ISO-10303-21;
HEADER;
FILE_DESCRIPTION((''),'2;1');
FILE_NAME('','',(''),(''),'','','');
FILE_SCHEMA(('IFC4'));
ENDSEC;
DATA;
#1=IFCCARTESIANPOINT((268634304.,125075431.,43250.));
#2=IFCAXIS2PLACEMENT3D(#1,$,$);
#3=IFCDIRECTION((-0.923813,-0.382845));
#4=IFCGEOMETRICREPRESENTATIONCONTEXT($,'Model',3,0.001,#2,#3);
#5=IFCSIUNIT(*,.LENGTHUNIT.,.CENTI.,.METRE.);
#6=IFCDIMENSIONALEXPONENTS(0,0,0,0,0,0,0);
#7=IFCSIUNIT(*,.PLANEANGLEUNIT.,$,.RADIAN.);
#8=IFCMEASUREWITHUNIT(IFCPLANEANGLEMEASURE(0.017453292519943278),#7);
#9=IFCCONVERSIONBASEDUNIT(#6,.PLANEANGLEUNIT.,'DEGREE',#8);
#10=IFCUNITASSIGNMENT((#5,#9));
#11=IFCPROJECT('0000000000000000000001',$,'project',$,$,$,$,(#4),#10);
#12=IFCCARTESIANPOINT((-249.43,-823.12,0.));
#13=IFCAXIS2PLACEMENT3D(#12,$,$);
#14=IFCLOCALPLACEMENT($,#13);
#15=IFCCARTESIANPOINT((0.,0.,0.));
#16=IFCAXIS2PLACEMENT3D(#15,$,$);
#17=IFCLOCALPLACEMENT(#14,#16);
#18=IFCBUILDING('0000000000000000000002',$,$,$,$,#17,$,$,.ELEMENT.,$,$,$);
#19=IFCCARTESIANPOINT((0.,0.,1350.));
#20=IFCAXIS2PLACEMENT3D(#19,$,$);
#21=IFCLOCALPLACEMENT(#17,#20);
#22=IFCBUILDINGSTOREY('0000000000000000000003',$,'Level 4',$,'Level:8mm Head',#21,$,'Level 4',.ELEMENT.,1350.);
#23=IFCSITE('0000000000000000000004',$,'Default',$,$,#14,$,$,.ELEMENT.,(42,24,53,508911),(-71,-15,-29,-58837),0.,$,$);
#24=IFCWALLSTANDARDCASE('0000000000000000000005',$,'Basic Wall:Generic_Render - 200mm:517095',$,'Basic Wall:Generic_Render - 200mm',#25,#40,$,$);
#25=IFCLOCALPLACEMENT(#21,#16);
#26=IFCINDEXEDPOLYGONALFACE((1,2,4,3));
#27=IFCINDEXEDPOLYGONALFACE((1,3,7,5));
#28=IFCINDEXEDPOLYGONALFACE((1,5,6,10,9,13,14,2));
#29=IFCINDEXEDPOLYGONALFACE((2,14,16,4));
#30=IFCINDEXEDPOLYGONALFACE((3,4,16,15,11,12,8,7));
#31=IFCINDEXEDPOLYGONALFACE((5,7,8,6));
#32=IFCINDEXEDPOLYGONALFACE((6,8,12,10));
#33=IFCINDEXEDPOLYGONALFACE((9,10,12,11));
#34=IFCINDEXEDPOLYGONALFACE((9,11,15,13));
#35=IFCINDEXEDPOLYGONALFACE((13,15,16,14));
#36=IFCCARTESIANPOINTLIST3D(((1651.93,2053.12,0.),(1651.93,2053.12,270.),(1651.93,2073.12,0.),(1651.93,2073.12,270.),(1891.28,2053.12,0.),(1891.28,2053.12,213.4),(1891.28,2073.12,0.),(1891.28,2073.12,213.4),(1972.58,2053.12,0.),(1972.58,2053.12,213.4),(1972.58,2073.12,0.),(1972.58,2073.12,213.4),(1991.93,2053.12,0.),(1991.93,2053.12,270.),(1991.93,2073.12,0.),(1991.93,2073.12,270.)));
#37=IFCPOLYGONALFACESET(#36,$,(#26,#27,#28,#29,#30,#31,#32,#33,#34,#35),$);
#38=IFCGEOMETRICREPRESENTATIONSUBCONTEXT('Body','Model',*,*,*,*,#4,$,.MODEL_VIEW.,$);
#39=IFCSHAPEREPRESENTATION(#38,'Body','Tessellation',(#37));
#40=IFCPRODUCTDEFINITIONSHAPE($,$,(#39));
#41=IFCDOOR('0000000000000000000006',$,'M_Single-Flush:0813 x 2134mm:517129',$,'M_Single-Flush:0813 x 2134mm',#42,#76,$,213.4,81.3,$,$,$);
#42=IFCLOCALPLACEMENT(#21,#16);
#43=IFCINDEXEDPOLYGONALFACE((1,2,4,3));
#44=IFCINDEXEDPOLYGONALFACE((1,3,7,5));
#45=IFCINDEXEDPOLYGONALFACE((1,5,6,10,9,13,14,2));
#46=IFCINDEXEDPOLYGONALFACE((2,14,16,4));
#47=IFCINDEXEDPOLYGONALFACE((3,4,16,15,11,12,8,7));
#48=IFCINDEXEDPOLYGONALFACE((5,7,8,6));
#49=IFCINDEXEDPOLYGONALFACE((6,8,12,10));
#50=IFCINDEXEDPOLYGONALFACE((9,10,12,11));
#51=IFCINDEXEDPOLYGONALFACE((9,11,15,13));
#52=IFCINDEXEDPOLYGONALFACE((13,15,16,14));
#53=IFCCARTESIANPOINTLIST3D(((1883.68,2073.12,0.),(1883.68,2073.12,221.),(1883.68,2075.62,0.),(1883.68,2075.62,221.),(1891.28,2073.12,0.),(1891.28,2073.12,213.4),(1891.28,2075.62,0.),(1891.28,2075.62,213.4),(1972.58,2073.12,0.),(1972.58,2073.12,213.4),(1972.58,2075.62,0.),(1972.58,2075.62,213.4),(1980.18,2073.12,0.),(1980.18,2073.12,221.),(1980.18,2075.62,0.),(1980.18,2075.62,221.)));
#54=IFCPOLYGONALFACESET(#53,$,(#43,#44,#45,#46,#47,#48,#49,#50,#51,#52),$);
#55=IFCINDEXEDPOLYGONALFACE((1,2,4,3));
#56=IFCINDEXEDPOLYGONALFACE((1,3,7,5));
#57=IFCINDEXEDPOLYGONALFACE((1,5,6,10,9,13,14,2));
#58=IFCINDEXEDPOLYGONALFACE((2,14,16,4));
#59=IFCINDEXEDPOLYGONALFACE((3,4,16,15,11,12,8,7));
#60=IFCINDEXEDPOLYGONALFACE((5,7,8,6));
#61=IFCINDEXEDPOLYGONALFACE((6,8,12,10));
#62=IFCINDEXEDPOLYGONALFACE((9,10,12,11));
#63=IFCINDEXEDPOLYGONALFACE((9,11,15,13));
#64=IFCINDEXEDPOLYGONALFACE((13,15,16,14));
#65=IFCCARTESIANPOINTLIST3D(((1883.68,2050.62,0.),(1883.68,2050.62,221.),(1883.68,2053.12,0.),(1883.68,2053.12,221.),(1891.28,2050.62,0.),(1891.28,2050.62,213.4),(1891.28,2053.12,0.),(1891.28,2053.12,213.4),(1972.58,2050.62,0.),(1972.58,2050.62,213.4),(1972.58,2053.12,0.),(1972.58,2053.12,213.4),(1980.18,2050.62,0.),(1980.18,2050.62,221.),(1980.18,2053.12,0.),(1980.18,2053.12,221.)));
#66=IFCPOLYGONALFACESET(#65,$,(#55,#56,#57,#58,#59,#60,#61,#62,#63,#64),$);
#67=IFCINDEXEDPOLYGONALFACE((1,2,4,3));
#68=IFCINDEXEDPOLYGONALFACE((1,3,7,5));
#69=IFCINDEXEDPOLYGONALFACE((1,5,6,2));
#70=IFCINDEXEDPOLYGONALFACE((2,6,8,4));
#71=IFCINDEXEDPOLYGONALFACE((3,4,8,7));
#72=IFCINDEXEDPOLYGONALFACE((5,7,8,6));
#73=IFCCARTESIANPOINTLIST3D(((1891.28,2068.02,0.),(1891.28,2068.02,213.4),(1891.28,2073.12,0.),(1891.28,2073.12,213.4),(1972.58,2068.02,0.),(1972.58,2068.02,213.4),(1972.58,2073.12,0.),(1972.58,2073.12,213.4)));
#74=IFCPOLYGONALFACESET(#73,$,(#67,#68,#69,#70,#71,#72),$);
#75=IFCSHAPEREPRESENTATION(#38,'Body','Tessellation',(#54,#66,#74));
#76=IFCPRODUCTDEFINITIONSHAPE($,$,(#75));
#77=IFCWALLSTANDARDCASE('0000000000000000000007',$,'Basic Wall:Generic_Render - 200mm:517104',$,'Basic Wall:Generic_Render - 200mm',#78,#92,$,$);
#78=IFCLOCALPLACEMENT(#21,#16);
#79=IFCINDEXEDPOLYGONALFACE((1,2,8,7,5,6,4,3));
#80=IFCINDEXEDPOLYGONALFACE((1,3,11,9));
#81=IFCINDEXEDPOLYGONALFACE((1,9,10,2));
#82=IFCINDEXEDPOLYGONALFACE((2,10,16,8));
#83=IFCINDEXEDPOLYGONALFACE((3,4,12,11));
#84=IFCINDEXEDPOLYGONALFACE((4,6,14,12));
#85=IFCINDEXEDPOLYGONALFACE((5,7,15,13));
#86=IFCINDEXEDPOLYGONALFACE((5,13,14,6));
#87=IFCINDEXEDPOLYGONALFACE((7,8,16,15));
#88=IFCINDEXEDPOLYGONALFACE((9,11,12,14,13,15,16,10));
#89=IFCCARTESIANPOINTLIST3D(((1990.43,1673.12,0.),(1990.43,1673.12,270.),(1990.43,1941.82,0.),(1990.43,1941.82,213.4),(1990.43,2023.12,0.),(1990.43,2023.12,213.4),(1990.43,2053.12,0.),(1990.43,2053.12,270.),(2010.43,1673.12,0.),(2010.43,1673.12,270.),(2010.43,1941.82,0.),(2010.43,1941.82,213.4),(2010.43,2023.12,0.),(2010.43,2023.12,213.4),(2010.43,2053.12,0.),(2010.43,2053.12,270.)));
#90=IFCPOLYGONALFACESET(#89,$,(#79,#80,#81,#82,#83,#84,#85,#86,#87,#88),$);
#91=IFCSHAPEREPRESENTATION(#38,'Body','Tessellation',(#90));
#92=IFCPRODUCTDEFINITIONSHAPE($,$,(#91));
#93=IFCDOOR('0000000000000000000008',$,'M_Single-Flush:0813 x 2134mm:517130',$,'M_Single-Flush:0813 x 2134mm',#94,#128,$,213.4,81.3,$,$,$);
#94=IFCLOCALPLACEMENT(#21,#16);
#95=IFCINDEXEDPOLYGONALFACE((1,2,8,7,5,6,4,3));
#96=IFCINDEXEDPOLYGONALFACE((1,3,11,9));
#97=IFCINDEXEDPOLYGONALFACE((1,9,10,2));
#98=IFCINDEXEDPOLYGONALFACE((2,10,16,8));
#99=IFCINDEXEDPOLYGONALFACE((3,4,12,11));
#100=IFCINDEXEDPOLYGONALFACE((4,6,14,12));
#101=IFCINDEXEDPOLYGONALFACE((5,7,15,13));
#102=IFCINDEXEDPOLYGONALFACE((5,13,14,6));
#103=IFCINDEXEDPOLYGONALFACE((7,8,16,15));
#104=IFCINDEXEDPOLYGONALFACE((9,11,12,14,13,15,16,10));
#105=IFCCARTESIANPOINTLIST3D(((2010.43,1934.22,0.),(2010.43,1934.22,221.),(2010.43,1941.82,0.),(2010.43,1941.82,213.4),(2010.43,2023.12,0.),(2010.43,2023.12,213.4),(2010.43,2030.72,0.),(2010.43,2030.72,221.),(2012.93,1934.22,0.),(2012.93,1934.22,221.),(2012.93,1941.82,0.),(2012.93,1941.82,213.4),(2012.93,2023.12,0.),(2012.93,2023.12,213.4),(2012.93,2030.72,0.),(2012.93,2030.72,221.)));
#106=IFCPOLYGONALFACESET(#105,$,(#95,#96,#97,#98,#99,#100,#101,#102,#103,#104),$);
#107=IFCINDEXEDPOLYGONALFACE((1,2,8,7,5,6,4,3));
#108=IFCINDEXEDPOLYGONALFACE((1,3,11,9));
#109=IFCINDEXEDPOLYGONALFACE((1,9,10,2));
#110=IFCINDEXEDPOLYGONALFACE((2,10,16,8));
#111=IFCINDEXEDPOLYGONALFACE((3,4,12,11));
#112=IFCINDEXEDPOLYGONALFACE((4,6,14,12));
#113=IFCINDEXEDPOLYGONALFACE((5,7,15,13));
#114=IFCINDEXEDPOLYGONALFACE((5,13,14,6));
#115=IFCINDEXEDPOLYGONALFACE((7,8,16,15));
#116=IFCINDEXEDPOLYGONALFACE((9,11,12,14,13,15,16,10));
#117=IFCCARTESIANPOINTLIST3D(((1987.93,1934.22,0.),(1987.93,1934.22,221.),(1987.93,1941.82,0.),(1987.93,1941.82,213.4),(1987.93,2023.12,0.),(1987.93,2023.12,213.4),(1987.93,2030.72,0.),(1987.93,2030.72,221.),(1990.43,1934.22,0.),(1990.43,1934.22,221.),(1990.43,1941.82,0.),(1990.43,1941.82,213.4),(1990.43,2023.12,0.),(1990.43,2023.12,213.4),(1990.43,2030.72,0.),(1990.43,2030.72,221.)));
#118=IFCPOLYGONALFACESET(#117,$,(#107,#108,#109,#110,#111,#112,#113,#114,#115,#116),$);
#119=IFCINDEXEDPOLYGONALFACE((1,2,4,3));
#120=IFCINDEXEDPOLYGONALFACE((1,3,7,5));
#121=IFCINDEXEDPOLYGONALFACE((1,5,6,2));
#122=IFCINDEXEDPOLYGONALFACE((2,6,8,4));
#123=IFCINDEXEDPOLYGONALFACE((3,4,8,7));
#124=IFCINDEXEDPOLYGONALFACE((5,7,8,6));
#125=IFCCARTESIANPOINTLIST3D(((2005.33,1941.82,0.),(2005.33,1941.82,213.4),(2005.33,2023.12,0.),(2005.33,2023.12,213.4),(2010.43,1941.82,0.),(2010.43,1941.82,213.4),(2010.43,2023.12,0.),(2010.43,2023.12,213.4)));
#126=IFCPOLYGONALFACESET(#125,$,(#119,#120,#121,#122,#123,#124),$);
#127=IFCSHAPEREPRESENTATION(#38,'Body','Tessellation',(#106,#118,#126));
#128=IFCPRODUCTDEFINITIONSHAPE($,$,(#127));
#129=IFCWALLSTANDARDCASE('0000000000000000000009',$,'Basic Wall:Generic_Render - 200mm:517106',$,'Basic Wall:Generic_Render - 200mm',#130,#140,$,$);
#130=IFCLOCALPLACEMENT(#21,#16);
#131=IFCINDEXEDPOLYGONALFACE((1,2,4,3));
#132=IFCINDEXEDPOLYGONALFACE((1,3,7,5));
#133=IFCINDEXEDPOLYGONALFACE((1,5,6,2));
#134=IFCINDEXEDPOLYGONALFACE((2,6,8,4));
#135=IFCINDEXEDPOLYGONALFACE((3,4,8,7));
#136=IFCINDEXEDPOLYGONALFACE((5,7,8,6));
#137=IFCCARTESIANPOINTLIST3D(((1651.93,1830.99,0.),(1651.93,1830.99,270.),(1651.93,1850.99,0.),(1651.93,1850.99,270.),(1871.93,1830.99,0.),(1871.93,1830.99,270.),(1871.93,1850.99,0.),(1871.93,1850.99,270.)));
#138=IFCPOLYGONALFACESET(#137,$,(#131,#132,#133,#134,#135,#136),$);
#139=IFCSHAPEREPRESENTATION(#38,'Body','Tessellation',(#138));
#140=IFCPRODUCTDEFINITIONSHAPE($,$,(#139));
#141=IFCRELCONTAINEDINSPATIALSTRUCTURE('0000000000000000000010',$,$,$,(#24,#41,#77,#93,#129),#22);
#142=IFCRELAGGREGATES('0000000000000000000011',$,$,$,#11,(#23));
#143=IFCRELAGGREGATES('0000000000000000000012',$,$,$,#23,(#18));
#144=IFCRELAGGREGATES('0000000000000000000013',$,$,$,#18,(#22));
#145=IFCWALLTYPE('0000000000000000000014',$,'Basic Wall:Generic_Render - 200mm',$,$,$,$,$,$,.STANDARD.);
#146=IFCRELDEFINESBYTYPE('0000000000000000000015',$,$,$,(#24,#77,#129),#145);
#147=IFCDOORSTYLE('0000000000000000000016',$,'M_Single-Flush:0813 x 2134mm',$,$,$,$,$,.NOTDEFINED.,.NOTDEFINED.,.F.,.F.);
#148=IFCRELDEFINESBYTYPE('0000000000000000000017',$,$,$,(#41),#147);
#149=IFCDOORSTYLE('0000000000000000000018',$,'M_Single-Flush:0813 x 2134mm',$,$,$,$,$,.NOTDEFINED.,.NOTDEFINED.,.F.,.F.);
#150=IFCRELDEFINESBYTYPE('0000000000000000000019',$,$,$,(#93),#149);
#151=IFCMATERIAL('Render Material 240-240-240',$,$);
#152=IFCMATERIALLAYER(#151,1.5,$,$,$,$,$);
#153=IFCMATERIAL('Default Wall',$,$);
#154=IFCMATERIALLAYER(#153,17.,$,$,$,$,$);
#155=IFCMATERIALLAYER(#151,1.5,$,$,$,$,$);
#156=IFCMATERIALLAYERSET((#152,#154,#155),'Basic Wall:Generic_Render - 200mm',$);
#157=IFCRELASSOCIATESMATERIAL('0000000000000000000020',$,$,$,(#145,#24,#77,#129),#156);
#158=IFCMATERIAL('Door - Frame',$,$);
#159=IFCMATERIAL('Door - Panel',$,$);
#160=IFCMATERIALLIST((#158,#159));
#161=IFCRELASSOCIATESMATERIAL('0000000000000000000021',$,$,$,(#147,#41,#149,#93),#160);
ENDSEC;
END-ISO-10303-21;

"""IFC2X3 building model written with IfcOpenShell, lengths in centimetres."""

from ifc_helpers import new_model, entity, si_unit, converted_unit, direction, frame, frame_2d, origin, place, context, subcontext, project, spatial, polyline, rectangle, outline, extrude, source, transform, mapped, material, material_list, layer, layer_set, layer_usage, type_object, type_shapes, element, fill, save


model = new_model("IFC2X3")

# Units and contexts
model_context = context("Model", 3, precision=0.001, world=frame((268634304.0, 125075431.0, 43250.0)), true_north=direction((-0.923813, -0.382845)))
body_context = subcontext(model_context, "Body", "Model", "MODEL_VIEW")
ifc_project = project(units=[si_unit("LENGTHUNIT", "METRE", prefix="CENTI"), converted_unit("PLANEANGLEUNIT", "DEGREE", entity("IfcPlaneAngleMeasure", 0.017453292519943278), si_unit("PLANEANGLEUNIT", "RADIAN"), dimensions=[0, 0, 0, 0, 0, 0, 0])], contexts=[model_context])

# Site, building, storey
site_placement = place(None, frame((-249.43, -823.12, 0.0)))
site = spatial("IfcSite", under=ifc_project, at=site_placement, Name="Default", CompositionType="ELEMENT", RefLatitude=(42, 24, 53, 508911), RefLongitude=(-71, -15, -29, -58837), RefElevation=0.0)
building_placement = place(site_placement, origin())
building = spatial("IfcBuilding", under=site, at=building_placement, CompositionType="ELEMENT")
storey_placement = place(building_placement, frame((0.0, 0.0, 1350.0)))
storey = spatial("IfcBuildingStorey", under=building, at=storey_placement, Name="Level 4", ObjectType="Level:8mm Head", LongName="Level 4", CompositionType="ELEMENT", Elevation=1350.0)

# Shared definitions
ifc_material_1 = material(Name="Render Material 240-240-240")
ifc_material_2 = material(Name="Default Wall")
ifc_layer_1 = layer(ifc_material_1, 1.5)
ifc_layer_2 = layer(ifc_material_2, 17.0)
ifc_layer_3 = layer(ifc_material_1, 1.5)
ifc_layer_set_1 = layer_set([ifc_layer_1, ifc_layer_2, ifc_layer_3], Name="Basic Wall:Generic_Render - 200mm")
wall_type_1 = type_object("IfcWallType", Name="Basic Wall:Generic_Render - 200mm", PredefinedType="STANDARD", material=ifc_layer_set_1)

# Walls, openings, doors
ifc_layer_usage_1 = layer_usage(ifc_layer_set_1, "AXIS2", "NEGATIVE", 10.0)
wall_1_placement = place(storey_placement, frame((1651.93, 2063.12, 0.0)))
wall_1 = element("IfcWallStandardCase", 1, at=wall_1_placement, inside=storey, type_object=wall_type_1, material=ifc_layer_usage_1, Name="Basic Wall:Generic_Render - 200mm:517095", ObjectType="Basic Wall:Generic_Render - 200mm", context=body_context, shape_type="SweptSolid", body=[
    extrude(rectangle(XDim=340.0, YDim=20.0, at=frame_2d((170.0, 0.0), x_axis=(1.0, 0.0))), origin(), (0.0, 0.0, 1.0), 270.0),
])
opening_1_placement = place(wall_1_placement, frame((239.35, -10.0, 0.0)))
opening_1 = element("IfcOpeningElement", 2, at=opening_1_placement, cuts=wall_1, ObjectType="Opening", context=body_context, shape_type="SweptSolid", body=[
    extrude(rectangle(XDim=81.3, YDim=213.4, at=frame_2d((106.7, 40.65), x_axis=(0.0, 1.0))), frame((0.0, 0.0, 0.0), z_axis=(0.0, 1.0, 0.0), x_axis=(0.0, 0.0, 1.0)), (0.0, 0.0, 1.0), 20.0),
])
ifc_material_3 = material(Name="Door - Frame")
ifc_material_4 = material(Name="Door - Panel")
ifc_material_list_1 = material_list([ifc_material_3, ifc_material_4])
door_style_1 = type_object("IfcDoorStyle", Name="M_Single-Flush:0813 x 2134mm", ConstructionType="NOTDEFINED", OperationType="NOTDEFINED", ParameterTakesPrecedence=False, Sizeable=False, material=ifc_material_list_1)
shared_shape_1 = source(origin(), body_context, "Body", "SweptSolid", [
    extrude(outline(polyline([(-48.25, -112.4), (48.25, -112.4), (48.25, 108.6), (40.65, 108.6), (40.65, -104.8), (-40.65, -104.8), (-40.65, 108.6), (-48.25, 108.6), (-48.25, -112.4)])), frame((40.65, 20.0, 108.6), z_axis=(0.0, 1.0, 0.0), x_axis=(1.0, 0.0, 0.0)), (0.0, 0.0, 1.0), 2.5),
    extrude(outline(polyline([(-112.4, -48.25), (108.6, -48.25), (108.6, -40.65), (-104.8, -40.65), (-104.8, 40.65), (108.6, 40.65), (108.6, 48.25), (-112.4, 48.25), (-112.4, -48.25)])), frame((40.65, -2.5, 108.6), z_axis=(0.0, 1.0, 0.0), x_axis=(0.0, 0.0, -1.0)), (0.0, 0.0, 1.0), 2.5),
    extrude(rectangle(XDim=5.1, YDim=81.3, at=frame_2d((0.0, 0.0), x_axis=(1.0, 0.0))), frame((40.65, 17.45, 0.0), z_axis=(0.0, 0.0, 1.0), x_axis=(0.0, 1.0, 0.0)), (0.0, 0.0, 1.0), 213.4),
])
type_shapes(door_style_1, [shared_shape_1])
door_1_placement = place(opening_1_placement, origin())
door_1 = element("IfcDoor", 3, at=door_1_placement, inside=storey, type_object=door_style_1, material=ifc_material_list_1, Name="M_Single-Flush:0813 x 2134mm:517129", ObjectType="M_Single-Flush:0813 x 2134mm", OverallHeight=213.4, OverallWidth=81.3, context=body_context, shape_type="MappedRepresentation", body=[
    mapped(shared_shape_1, transform((0.0, 0.0, 0.0), scale=1.0)),
])
fill(opening_1, door_1)
ifc_layer_usage_2 = layer_usage(ifc_layer_set_1, "AXIS2", "NEGATIVE", 10.0)
wall_2_placement = place(storey_placement, frame((2000.43, 2053.12, 0.0), z_axis=(0.0, 0.0, 1.0), x_axis=(0.0, -1.0, 0.0)))
wall_2 = element("IfcWallStandardCase", 4, at=wall_2_placement, inside=storey, type_object=wall_type_1, material=ifc_layer_usage_2, Name="Basic Wall:Generic_Render - 200mm:517104", ObjectType="Basic Wall:Generic_Render - 200mm", context=body_context, shape_type="SweptSolid", body=[
    extrude(rectangle(XDim=380.0, YDim=20.0, at=frame_2d((190.0, 0.0), x_axis=(-1.0, 0.0))), origin(), (0.0, 0.0, 1.0), 270.0),
])
opening_2_placement = place(wall_2_placement, frame((30.0, -10.0, 0.0)))
opening_2 = element("IfcOpeningElement", 5, at=opening_2_placement, cuts=wall_2, ObjectType="Opening", context=body_context, shape_type="SweptSolid", body=[
    extrude(rectangle(XDim=81.3, YDim=213.4, at=frame_2d((106.7, 40.65), x_axis=(0.0, -1.0))), frame((0.0, 0.0, 0.0), z_axis=(0.0, 1.0, 0.0), x_axis=(0.0, 0.0, 1.0)), (0.0, 0.0, 1.0), 20.0),
])
door_style_2 = type_object("IfcDoorStyle", Name="M_Single-Flush:0813 x 2134mm", ConstructionType="NOTDEFINED", OperationType="NOTDEFINED", ParameterTakesPrecedence=False, Sizeable=False, material=ifc_material_list_1)
shared_shape_2 = source(origin(), body_context, "Body", "SweptSolid", [
    extrude(outline(polyline([(-48.25, -112.4), (48.25, -112.4), (48.25, 108.6), (40.65, 108.6), (40.65, -104.8), (-40.65, -104.8), (-40.65, 108.6), (-48.25, 108.6), (-48.25, -112.4)])), frame((40.65, 22.5, 108.6), z_axis=(0.0, -1.0, 0.0), x_axis=(-1.0, 0.0, 0.0)), (0.0, 0.0, 1.0), 2.5),
    extrude(outline(polyline([(-112.4, -48.25), (108.6, -48.25), (108.6, -40.65), (-104.8, -40.65), (-104.8, 40.65), (108.6, 40.65), (108.6, 48.25), (-112.4, 48.25), (-112.4, -48.25)])), frame((40.65, 0.0, 108.6), z_axis=(0.0, -1.0, 0.0), x_axis=(0.0, 0.0, -1.0)), (0.0, 0.0, 1.0), 2.5),
    extrude(rectangle(XDim=81.3, YDim=5.1, at=frame_2d((0.0, 0.0), x_axis=(1.0, 0.0))), frame((40.65, 17.45, 0.0)), (0.0, 0.0, 1.0), 213.4),
])
type_shapes(door_style_2, [shared_shape_2])
door_2_placement = place(opening_2_placement, origin())
door_2 = element("IfcDoor", 6, at=door_2_placement, inside=storey, type_object=door_style_2, material=ifc_material_list_1, Name="M_Single-Flush:0813 x 2134mm:517130", ObjectType="M_Single-Flush:0813 x 2134mm", OverallHeight=213.4, OverallWidth=81.3, context=body_context, shape_type="MappedRepresentation", body=[
    mapped(shared_shape_2, transform((0.0, 0.0, 0.0), scale=1.0)),
])
fill(opening_2, door_2)

# Wall
ifc_layer_usage_3 = layer_usage(ifc_layer_set_1, "AXIS2", "NEGATIVE", 10.0)
wall_3_placement = place(storey_placement, frame((1651.93, 1840.99, 0.0)))
element("IfcWallStandardCase", 7, at=wall_3_placement, inside=storey, type_object=wall_type_1, material=ifc_layer_usage_3, Name="Basic Wall:Generic_Render - 200mm:517106", ObjectType="Basic Wall:Generic_Render - 200mm", context=body_context, shape_type="SweptSolid", body=[
    extrude(rectangle(XDim=220.0, YDim=20.0, at=frame_2d((110.0, 0.0), x_axis=(-1.0, 0.0))), origin(), (0.0, 0.0, 1.0), 270.0),
])

save(model, "model.ifc")
